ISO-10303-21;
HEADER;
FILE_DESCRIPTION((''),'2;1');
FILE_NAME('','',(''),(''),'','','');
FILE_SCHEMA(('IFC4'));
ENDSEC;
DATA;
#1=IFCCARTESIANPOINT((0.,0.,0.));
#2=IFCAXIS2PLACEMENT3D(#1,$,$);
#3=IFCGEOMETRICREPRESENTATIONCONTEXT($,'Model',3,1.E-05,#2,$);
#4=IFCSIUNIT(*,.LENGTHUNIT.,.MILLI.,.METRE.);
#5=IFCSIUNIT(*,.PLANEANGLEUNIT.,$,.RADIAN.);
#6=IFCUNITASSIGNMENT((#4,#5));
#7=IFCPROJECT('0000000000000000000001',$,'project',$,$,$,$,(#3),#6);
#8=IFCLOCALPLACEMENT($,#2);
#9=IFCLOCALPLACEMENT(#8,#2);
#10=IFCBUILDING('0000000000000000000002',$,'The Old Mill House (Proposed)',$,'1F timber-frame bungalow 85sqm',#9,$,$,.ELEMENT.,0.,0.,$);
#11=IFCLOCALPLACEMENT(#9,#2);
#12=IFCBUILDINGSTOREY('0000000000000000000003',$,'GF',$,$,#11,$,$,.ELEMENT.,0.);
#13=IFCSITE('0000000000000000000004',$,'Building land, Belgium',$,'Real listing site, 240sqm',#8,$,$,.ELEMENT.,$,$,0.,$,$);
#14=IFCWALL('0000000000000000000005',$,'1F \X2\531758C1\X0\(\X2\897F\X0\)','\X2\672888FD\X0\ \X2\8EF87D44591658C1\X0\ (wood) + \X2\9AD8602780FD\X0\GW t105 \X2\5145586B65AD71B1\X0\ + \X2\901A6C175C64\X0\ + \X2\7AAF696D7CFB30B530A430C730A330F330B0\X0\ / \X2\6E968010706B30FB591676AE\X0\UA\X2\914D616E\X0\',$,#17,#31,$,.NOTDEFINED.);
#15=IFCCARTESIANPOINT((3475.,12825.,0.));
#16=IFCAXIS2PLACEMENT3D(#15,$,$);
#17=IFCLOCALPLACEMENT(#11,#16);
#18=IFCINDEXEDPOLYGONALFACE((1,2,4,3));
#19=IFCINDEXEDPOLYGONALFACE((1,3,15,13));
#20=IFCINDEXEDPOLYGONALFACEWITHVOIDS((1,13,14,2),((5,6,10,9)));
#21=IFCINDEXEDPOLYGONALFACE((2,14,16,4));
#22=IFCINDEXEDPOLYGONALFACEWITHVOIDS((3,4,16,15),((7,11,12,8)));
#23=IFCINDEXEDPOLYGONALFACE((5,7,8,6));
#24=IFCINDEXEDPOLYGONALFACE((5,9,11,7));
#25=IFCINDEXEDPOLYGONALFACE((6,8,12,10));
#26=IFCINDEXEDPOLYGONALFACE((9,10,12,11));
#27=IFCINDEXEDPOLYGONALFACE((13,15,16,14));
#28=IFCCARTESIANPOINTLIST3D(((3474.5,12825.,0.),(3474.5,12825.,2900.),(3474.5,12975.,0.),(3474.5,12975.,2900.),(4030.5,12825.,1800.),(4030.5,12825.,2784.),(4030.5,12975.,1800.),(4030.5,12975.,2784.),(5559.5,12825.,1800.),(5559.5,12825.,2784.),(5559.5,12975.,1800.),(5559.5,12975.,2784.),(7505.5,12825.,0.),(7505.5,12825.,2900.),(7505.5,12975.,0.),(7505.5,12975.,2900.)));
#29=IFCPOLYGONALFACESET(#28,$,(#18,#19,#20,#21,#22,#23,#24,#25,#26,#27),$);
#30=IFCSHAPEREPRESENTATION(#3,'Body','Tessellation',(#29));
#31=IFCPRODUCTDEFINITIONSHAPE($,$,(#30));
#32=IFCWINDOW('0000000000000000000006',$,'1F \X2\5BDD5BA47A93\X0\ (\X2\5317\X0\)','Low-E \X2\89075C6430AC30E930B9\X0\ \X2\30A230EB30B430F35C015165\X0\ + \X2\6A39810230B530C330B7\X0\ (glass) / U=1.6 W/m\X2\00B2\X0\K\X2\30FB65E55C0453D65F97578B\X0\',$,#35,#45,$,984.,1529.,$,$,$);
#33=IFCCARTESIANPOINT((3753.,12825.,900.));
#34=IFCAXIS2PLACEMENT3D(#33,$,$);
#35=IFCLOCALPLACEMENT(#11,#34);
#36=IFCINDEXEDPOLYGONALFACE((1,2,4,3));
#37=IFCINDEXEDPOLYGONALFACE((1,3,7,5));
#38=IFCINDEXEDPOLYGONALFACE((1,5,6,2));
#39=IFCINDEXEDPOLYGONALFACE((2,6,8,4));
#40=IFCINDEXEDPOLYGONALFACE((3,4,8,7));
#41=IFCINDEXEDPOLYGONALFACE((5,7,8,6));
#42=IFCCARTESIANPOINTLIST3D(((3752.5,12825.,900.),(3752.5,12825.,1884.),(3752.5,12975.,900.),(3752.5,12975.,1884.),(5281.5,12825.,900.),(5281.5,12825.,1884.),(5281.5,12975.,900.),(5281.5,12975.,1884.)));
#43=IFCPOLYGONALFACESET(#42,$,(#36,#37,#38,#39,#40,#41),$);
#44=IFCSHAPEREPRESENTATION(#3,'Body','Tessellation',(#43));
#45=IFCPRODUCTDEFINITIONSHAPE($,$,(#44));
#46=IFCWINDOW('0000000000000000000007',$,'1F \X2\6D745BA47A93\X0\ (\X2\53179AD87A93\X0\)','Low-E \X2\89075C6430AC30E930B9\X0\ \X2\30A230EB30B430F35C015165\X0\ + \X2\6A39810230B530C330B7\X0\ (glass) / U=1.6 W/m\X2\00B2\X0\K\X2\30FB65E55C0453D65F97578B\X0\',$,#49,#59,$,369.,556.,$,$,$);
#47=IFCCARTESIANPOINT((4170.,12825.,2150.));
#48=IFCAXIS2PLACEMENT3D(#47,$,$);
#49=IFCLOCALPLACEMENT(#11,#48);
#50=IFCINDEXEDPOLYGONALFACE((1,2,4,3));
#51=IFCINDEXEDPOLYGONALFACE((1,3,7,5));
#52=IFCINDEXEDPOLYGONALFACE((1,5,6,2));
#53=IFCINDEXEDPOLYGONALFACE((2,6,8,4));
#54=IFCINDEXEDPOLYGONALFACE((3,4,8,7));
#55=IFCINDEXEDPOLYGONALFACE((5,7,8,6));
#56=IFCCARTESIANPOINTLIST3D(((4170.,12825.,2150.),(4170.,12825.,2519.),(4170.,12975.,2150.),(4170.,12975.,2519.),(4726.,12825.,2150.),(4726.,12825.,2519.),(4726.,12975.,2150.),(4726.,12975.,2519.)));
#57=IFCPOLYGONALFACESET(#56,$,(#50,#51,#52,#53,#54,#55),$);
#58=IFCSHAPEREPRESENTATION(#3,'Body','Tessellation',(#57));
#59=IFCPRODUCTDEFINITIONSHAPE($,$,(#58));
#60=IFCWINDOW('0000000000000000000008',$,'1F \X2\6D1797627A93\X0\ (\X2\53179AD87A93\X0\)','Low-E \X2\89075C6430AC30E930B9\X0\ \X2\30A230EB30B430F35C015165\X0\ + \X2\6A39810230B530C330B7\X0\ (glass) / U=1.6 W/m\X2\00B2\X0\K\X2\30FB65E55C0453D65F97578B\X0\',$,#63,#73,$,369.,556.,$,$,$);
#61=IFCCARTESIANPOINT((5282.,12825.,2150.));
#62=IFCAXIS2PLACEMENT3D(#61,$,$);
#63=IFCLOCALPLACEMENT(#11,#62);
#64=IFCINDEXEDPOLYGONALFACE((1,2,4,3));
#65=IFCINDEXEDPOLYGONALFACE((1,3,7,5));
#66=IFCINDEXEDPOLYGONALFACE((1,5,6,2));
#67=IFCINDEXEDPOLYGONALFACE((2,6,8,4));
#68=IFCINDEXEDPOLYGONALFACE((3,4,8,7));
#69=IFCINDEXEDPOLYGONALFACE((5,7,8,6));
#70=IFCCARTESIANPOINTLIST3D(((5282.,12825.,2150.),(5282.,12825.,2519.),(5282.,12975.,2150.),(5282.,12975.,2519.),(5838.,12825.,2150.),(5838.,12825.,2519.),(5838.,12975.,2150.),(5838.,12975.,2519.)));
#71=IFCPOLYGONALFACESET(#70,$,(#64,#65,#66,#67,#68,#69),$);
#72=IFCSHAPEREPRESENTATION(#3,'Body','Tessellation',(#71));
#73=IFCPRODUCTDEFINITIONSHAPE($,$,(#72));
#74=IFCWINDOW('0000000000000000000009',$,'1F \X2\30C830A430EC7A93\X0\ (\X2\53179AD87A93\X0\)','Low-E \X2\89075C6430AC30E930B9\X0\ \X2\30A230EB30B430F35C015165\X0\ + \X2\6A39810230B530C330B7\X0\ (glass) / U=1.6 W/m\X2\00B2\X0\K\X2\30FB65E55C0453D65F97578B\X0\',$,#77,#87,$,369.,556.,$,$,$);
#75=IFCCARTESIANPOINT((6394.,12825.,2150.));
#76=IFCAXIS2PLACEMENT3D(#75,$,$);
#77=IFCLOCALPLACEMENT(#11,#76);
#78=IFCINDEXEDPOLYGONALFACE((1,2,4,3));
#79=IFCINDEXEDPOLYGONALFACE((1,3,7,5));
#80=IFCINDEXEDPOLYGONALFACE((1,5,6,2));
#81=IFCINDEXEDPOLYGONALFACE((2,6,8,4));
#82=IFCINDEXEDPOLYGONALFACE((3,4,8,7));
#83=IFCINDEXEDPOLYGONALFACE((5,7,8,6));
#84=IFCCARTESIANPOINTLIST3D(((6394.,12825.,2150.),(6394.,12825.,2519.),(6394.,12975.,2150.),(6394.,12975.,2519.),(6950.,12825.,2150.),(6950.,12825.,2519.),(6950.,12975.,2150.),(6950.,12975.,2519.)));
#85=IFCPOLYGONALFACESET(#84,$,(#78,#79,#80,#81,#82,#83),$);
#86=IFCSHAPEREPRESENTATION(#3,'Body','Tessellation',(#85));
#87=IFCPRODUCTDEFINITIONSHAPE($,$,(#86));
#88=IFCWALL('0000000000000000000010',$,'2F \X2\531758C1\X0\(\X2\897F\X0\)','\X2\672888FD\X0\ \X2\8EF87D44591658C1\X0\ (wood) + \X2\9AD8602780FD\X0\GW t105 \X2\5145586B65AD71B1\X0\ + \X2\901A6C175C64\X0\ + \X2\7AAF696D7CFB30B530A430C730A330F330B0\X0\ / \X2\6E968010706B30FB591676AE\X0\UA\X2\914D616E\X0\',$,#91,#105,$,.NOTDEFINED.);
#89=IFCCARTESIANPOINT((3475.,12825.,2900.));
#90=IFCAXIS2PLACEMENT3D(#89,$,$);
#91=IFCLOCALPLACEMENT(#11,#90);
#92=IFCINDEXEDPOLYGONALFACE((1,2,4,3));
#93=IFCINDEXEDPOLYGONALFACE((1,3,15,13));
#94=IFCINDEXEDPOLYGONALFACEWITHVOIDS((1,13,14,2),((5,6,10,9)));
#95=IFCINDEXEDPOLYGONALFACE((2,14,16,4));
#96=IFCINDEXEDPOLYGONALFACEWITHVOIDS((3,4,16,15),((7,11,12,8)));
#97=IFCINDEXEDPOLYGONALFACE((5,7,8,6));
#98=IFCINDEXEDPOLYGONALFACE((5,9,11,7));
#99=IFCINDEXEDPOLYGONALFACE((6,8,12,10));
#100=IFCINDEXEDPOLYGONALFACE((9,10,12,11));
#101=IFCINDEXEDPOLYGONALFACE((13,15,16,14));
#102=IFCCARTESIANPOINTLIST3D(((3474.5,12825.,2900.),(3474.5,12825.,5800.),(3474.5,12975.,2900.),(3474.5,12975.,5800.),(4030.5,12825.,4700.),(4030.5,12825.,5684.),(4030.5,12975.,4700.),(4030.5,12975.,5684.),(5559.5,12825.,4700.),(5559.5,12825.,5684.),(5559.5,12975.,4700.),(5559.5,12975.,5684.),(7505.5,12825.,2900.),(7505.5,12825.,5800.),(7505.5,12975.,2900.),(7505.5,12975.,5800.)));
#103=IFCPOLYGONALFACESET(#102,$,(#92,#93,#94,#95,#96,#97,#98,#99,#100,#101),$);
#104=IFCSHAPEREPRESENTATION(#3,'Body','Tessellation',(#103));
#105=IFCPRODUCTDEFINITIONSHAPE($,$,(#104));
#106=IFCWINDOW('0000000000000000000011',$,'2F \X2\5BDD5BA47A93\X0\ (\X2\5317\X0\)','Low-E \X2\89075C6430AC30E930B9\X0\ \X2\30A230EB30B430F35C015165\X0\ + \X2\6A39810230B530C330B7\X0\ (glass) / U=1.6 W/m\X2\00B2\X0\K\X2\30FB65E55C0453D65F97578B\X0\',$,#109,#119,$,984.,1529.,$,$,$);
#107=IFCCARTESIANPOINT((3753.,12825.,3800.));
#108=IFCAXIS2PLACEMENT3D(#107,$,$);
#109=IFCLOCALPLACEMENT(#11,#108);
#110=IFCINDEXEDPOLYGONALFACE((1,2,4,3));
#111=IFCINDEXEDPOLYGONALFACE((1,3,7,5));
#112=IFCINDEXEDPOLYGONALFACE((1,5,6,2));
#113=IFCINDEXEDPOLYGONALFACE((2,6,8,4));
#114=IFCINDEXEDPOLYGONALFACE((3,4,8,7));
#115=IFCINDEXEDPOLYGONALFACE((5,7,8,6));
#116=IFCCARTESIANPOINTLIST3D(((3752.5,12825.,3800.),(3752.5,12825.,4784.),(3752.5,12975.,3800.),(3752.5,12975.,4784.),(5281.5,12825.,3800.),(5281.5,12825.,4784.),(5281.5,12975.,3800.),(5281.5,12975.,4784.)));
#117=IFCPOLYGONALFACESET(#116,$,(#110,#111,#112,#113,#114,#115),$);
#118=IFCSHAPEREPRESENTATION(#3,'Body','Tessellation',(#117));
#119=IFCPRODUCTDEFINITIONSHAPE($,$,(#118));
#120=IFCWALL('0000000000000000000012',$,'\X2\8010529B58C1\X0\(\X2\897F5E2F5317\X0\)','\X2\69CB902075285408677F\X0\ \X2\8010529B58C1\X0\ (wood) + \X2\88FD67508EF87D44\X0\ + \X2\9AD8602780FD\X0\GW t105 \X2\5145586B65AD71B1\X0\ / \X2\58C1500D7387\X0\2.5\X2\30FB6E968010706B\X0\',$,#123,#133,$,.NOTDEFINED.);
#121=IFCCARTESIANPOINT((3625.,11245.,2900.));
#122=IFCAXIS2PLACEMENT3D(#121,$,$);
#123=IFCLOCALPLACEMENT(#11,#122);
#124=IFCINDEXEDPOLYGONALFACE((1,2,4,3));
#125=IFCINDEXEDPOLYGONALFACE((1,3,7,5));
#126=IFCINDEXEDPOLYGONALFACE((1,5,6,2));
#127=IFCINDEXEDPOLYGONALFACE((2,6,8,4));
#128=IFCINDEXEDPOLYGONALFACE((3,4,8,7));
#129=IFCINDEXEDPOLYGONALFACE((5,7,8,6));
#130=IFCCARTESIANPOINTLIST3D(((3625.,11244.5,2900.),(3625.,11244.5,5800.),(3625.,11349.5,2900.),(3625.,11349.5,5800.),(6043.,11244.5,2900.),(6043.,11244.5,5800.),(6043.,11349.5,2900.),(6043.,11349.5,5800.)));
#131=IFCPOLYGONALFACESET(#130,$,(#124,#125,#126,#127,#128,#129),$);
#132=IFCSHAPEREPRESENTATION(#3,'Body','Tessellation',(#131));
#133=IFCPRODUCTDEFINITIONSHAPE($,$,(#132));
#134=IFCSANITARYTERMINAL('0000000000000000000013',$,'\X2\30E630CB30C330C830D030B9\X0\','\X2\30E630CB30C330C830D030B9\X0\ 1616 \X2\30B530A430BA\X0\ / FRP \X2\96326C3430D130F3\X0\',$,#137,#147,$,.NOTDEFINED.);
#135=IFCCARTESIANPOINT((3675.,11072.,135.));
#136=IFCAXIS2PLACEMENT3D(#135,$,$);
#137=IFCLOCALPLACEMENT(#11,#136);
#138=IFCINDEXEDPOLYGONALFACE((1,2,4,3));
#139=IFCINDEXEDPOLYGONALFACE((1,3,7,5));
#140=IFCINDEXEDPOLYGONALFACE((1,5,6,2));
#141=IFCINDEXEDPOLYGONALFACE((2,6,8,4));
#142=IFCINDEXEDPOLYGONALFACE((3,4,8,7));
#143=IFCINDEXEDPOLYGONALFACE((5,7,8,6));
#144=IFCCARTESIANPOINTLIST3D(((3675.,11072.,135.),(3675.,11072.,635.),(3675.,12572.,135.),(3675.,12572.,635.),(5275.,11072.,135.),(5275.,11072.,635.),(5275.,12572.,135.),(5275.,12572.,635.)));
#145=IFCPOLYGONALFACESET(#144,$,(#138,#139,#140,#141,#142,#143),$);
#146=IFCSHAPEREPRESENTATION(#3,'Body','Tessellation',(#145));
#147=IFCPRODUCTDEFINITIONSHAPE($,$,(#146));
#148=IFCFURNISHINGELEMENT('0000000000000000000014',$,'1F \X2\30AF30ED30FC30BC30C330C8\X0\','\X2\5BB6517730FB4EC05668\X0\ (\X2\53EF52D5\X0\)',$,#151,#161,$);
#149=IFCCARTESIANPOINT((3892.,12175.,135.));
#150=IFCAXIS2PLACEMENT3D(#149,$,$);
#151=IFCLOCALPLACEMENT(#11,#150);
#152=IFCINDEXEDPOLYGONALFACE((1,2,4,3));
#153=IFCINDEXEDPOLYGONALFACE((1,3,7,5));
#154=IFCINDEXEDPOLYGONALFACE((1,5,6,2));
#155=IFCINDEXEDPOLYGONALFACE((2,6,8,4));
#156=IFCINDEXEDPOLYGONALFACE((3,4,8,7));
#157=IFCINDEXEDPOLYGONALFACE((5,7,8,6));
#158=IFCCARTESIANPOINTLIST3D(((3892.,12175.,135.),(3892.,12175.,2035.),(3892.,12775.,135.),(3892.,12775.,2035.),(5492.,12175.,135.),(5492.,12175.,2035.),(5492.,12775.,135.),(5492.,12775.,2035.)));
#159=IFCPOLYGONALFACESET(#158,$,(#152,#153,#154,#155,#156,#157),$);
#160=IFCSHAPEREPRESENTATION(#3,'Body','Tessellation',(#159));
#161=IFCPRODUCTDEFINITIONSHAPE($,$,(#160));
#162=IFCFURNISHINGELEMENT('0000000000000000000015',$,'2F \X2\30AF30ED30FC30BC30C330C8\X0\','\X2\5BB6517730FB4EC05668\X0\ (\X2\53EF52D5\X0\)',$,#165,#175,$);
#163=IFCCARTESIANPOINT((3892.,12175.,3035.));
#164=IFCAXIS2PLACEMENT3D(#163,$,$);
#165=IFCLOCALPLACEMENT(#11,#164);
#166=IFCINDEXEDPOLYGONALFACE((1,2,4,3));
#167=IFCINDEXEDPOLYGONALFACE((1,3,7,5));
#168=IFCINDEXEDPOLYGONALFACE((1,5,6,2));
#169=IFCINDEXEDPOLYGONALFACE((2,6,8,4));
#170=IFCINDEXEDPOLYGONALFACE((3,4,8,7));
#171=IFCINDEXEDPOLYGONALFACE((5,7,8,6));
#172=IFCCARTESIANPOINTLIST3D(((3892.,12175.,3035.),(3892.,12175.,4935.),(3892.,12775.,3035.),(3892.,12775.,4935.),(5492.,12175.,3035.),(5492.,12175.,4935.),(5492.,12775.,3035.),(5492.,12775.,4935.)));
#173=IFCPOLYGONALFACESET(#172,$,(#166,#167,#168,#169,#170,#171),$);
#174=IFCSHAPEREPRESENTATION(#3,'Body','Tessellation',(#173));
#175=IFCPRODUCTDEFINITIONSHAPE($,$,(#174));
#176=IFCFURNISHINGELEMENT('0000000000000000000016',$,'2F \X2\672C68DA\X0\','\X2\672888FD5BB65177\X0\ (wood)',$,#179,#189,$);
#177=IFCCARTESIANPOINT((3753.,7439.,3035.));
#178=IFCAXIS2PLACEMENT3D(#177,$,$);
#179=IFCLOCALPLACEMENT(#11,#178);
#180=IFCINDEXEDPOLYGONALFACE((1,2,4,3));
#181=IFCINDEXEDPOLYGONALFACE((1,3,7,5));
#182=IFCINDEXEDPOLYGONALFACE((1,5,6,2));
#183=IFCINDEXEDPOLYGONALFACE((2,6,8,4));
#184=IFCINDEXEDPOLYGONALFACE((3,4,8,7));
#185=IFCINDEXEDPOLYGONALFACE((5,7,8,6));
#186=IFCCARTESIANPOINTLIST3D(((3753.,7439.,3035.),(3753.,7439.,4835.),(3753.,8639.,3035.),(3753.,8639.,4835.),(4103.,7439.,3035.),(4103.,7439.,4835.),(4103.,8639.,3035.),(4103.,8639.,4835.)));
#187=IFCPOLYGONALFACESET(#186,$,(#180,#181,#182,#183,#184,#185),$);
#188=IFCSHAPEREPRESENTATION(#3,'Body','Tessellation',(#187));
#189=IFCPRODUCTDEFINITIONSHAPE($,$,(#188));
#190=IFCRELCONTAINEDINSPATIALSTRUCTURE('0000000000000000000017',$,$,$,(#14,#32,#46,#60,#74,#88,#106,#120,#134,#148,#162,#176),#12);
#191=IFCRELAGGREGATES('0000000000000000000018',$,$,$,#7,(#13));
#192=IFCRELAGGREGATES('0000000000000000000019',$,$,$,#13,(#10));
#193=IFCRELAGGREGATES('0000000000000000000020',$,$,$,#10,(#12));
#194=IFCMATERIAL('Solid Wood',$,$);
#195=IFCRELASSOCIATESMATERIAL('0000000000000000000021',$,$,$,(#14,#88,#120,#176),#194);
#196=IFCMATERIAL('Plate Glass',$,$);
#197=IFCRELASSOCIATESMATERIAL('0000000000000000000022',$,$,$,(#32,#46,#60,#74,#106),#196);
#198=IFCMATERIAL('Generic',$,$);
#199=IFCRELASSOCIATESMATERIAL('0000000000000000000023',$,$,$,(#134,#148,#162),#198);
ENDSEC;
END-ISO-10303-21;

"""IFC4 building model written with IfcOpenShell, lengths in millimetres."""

from ifc_helpers import new_model, si_unit, frame, frame_2d, origin, place, context, project, spatial, rectangle, extrude, material, element, fill, save


model = new_model("IFC4")

# Units and contexts
model_context = context("Model", 3, precision=1e-05, world=origin())
ifc_project = project(units=[si_unit("LENGTHUNIT", "METRE", prefix="MILLI"), si_unit("PLANEANGLEUNIT", "RADIAN")], contexts=[model_context])

# Site, building, storey
site_placement = place(None, origin())
site = spatial("IfcSite", under=ifc_project, at=site_placement, Name="Building land, Belgium", ObjectType="Real listing site, 240sqm", CompositionType="ELEMENT", RefElevation=0.0)
building_placement = place(site_placement, origin())
building = spatial("IfcBuilding", under=site, at=building_placement, Name="The Old Mill House (Proposed)", ObjectType="1F timber-frame bungalow 85sqm", CompositionType="ELEMENT", ElevationOfRefHeight=0.0, ElevationOfTerrain=0.0)
storey_placement = place(building_placement, origin())
storey = spatial("IfcBuildingStorey", under=building, at=storey_placement, Name="GF", CompositionType="ELEMENT", Elevation=0.0)

# Shared definitions
ifc_material_1 = material(Name="Solid Wood")

# Wall, openings, windows
wall_1_placement = place(storey_placement, frame((3475.0, 12825.0, 0.0)))
wall_1 = element("IfcWall", 1, at=wall_1_placement, inside=storey, material=ifc_material_1, Name="1F 北壁(西)", Description="木製 軸組外壁 (wood) + 高性能GW t105 充填断熱 + 通気層 + 窯業系サイディング / 準耐火・外皮UA配慮", PredefinedType="NOTDEFINED", context=model_context, shape_type="SweptSolid", body=[
    extrude(rectangle(XDim=4031.0, YDim=150.0, at=frame_2d((2015.0, 75.0))), frame((3475.0, 12825.0, 0.0)), (0.0, 0.0, 1.0), 2900.0),
])
opening_1_placement = place(storey_placement, frame((3753.0, 12825.0, 900.0)))
opening_1 = element("IfcOpeningElement", 2, at=opening_1_placement, cuts=wall_1, PredefinedType="NOTDEFINED", context=model_context, shape_type="SweptSolid", body=[
    extrude(rectangle(XDim=1529.0, YDim=150.0, at=frame_2d((764.0, 75.0))), frame((3753.0, 12825.0, 900.0)), (0.0, 0.0, 1.0), 984.0),
])
opening_2_placement = place(storey_placement, frame((4170.0, 12825.0, 2150.0)))
opening_2 = element("IfcOpeningElement", 3, at=opening_2_placement, cuts=wall_1, PredefinedType="NOTDEFINED", context=model_context, shape_type="SweptSolid", body=[
    extrude(rectangle(XDim=556.0, YDim=150.0, at=frame_2d((278.0, 75.0))), frame((4170.0, 12825.0, 2150.0)), (0.0, 0.0, 1.0), 369.0),
])
opening_3_placement = place(storey_placement, frame((5282.0, 12825.0, 2150.0)))
opening_3 = element("IfcOpeningElement", 4, at=opening_3_placement, cuts=wall_1, PredefinedType="NOTDEFINED", context=model_context, shape_type="SweptSolid", body=[
    extrude(rectangle(XDim=556.0, YDim=150.0, at=frame_2d((278.0, 75.0))), frame((5282.0, 12825.0, 2150.0)), (0.0, 0.0, 1.0), 369.0),
])
opening_4_placement = place(storey_placement, frame((6394.0, 12825.0, 2150.0)))
opening_4 = element("IfcOpeningElement", 5, at=opening_4_placement, cuts=wall_1, PredefinedType="NOTDEFINED", context=model_context, shape_type="SweptSolid", body=[
    extrude(rectangle(XDim=556.0, YDim=150.0, at=frame_2d((278.0, 75.0))), frame((6394.0, 12825.0, 2150.0)), (0.0, 0.0, 1.0), 369.0),
])
ifc_material_2 = material(Name="Plate Glass")
window_1_placement = place(storey_placement, frame((3753.0, 12825.0, 900.0)))
window_1 = element("IfcWindow", 6, at=window_1_placement, inside=storey, material=ifc_material_2, Name="1F 寝室窓 (北)", Description="Low-E 複層ガラス アルゴン封入 + 樹脂サッシ (glass) / U=1.6 W/m²K・日射取得型", OverallHeight=984.0, OverallWidth=1529.0, context=model_context, shape_type="SweptSolid", body=[
    extrude(rectangle(XDim=1529.0, YDim=150.0, at=frame_2d((764.0, 75.0))), frame((3753.0, 12825.0, 900.0)), (0.0, 0.0, 1.0), 984.0),
])
fill(opening_1, window_1)
window_2_placement = place(storey_placement, frame((4170.0, 12825.0, 2150.0)))
window_2 = element("IfcWindow", 7, at=window_2_placement, inside=storey, material=ifc_material_2, Name="1F 浴室窓 (北高窓)", Description="Low-E 複層ガラス アルゴン封入 + 樹脂サッシ (glass) / U=1.6 W/m²K・日射取得型", OverallHeight=369.0, OverallWidth=556.0, context=model_context, shape_type="SweptSolid", body=[
    extrude(rectangle(XDim=556.0, YDim=150.0, at=frame_2d((278.0, 75.0))), frame((4170.0, 12825.0, 2150.0)), (0.0, 0.0, 1.0), 369.0),
])
fill(opening_2, window_2)
window_3_placement = place(storey_placement, frame((5282.0, 12825.0, 2150.0)))
window_3 = element("IfcWindow", 8, at=window_3_placement, inside=storey, material=ifc_material_2, Name="1F 洗面窓 (北高窓)", Description="Low-E 複層ガラス アルゴン封入 + 樹脂サッシ (glass) / U=1.6 W/m²K・日射取得型", OverallHeight=369.0, OverallWidth=556.0, context=model_context, shape_type="SweptSolid", body=[
    extrude(rectangle(XDim=556.0, YDim=150.0, at=frame_2d((278.0, 75.0))), frame((5282.0, 12825.0, 2150.0)), (0.0, 0.0, 1.0), 369.0),
])
fill(opening_3, window_3)
window_4_placement = place(storey_placement, frame((6394.0, 12825.0, 2150.0)))
window_4 = element("IfcWindow", 9, at=window_4_placement, inside=storey, material=ifc_material_2, Name="1F トイレ窓 (北高窓)", Description="Low-E 複層ガラス アルゴン封入 + 樹脂サッシ (glass) / U=1.6 W/m²K・日射取得型", OverallHeight=369.0, OverallWidth=556.0, context=model_context, shape_type="SweptSolid", body=[
    extrude(rectangle(XDim=556.0, YDim=150.0, at=frame_2d((278.0, 75.0))), frame((6394.0, 12825.0, 2150.0)), (0.0, 0.0, 1.0), 369.0),
])
fill(opening_4, window_4)

# Wall, opening, window
wall_2_placement = place(storey_placement, frame((3475.0, 12825.0, 2900.0)))
wall_2 = element("IfcWall", 10, at=wall_2_placement, inside=storey, material=ifc_material_1, Name="2F 北壁(西)", Description="木製 軸組外壁 (wood) + 高性能GW t105 充填断熱 + 通気層 + 窯業系サイディング / 準耐火・外皮UA配慮", PredefinedType="NOTDEFINED", context=model_context, shape_type="SweptSolid", body=[
    extrude(rectangle(XDim=4031.0, YDim=150.0, at=frame_2d((2015.0, 75.0))), frame((3475.0, 12825.0, 2900.0)), (0.0, 0.0, 1.0), 2900.0),
])
opening_5_placement = place(storey_placement, frame((3753.0, 12825.0, 3800.0)))
opening_5 = element("IfcOpeningElement", 11, at=opening_5_placement, cuts=wall_2, PredefinedType="NOTDEFINED", context=model_context, shape_type="SweptSolid", body=[
    extrude(rectangle(XDim=1529.0, YDim=150.0, at=frame_2d((764.0, 75.0))), frame((3753.0, 12825.0, 3800.0)), (0.0, 0.0, 1.0), 984.0),
])
window_5_placement = place(storey_placement, frame((3753.0, 12825.0, 3800.0)))
window_5 = element("IfcWindow", 12, at=window_5_placement, inside=storey, material=ifc_material_2, Name="2F 寝室窓 (北)", Description="Low-E 複層ガラス アルゴン封入 + 樹脂サッシ (glass) / U=1.6 W/m²K・日射取得型", OverallHeight=984.0, OverallWidth=1529.0, context=model_context, shape_type="SweptSolid", body=[
    extrude(rectangle(XDim=1529.0, YDim=150.0, at=frame_2d((764.0, 75.0))), frame((3753.0, 12825.0, 3800.0)), (0.0, 0.0, 1.0), 984.0),
])
fill(opening_5, window_5)

# Wall
wall_3_placement = place(storey_placement, frame((3625.0, 11245.0, 2900.0)))
element("IfcWall", 13, at=wall_3_placement, inside=storey, material=ifc_material_1, Name="耐力壁(西帯北)", Description="構造用合板 耐力壁 (wood) + 製材軸組 + 高性能GW t105 充填断熱 / 壁倍率2.5・準耐火", PredefinedType="NOTDEFINED", context=model_context, shape_type="SweptSolid", body=[
    extrude(rectangle(XDim=2418.0, YDim=105.0, at=frame_2d((1209.0, 52.0))), frame((3625.0, 11245.0, 2900.0)), (0.0, 0.0, 1.0), 2900.0),
])

# Shared definitions
ifc_material_3 = material(Name="Generic")

# Sanitary terminal
sanitary_terminal_placement = place(storey_placement, frame((3675.0, 11072.0, 135.0)))
element("IfcSanitaryTerminal", 14, at=sanitary_terminal_placement, inside=storey, material=ifc_material_3, Name="ユニットバス", Description="ユニットバス 1616 サイズ / FRP 防水パン", PredefinedType="NOTDEFINED", context=model_context, shape_type="SweptSolid", body=[
    extrude(rectangle(XDim=1600.0, YDim=1500.0, at=frame_2d((800.0, 750.0))), frame((3675.0, 11072.0, 135.0)), (0.0, 0.0, 1.0), 500.0),
])

# Furnishing elements
furnishing_1_placement = place(storey_placement, frame((3892.0, 12175.0, 135.0)))
element("IfcFurnishingElement", 15, at=furnishing_1_placement, inside=storey, material=ifc_material_3, Name="1F クローゼット", Description="家具・什器 (可動)", context=model_context, shape_type="SweptSolid", body=[
    extrude(rectangle(XDim=1600.0, YDim=600.0, at=frame_2d((800.0, 300.0))), frame((3892.0, 12175.0, 135.0)), (0.0, 0.0, 1.0), 1900.0),
])
furnishing_2_placement = place(storey_placement, frame((3892.0, 12175.0, 3035.0)))
element("IfcFurnishingElement", 16, at=furnishing_2_placement, inside=storey, material=ifc_material_3, Name="2F クローゼット", Description="家具・什器 (可動)", context=model_context, shape_type="SweptSolid", body=[
    extrude(rectangle(XDim=1600.0, YDim=600.0, at=frame_2d((800.0, 300.0))), frame((3892.0, 12175.0, 3035.0)), (0.0, 0.0, 1.0), 1900.0),
])
furnishing_3_placement = place(storey_placement, frame((3753.0, 7439.0, 3035.0)))
element("IfcFurnishingElement", 17, at=furnishing_3_placement, inside=storey, material=ifc_material_1, Name="2F 本棚", Description="木製家具 (wood)", context=model_context, shape_type="SweptSolid", body=[
    extrude(rectangle(XDim=350.0, YDim=1200.0, at=frame_2d((175.0, 600.0))), frame((3753.0, 7439.0, 3035.0)), (0.0, 0.0, 1.0), 1800.0),
])

save(model, "model.ifc")
